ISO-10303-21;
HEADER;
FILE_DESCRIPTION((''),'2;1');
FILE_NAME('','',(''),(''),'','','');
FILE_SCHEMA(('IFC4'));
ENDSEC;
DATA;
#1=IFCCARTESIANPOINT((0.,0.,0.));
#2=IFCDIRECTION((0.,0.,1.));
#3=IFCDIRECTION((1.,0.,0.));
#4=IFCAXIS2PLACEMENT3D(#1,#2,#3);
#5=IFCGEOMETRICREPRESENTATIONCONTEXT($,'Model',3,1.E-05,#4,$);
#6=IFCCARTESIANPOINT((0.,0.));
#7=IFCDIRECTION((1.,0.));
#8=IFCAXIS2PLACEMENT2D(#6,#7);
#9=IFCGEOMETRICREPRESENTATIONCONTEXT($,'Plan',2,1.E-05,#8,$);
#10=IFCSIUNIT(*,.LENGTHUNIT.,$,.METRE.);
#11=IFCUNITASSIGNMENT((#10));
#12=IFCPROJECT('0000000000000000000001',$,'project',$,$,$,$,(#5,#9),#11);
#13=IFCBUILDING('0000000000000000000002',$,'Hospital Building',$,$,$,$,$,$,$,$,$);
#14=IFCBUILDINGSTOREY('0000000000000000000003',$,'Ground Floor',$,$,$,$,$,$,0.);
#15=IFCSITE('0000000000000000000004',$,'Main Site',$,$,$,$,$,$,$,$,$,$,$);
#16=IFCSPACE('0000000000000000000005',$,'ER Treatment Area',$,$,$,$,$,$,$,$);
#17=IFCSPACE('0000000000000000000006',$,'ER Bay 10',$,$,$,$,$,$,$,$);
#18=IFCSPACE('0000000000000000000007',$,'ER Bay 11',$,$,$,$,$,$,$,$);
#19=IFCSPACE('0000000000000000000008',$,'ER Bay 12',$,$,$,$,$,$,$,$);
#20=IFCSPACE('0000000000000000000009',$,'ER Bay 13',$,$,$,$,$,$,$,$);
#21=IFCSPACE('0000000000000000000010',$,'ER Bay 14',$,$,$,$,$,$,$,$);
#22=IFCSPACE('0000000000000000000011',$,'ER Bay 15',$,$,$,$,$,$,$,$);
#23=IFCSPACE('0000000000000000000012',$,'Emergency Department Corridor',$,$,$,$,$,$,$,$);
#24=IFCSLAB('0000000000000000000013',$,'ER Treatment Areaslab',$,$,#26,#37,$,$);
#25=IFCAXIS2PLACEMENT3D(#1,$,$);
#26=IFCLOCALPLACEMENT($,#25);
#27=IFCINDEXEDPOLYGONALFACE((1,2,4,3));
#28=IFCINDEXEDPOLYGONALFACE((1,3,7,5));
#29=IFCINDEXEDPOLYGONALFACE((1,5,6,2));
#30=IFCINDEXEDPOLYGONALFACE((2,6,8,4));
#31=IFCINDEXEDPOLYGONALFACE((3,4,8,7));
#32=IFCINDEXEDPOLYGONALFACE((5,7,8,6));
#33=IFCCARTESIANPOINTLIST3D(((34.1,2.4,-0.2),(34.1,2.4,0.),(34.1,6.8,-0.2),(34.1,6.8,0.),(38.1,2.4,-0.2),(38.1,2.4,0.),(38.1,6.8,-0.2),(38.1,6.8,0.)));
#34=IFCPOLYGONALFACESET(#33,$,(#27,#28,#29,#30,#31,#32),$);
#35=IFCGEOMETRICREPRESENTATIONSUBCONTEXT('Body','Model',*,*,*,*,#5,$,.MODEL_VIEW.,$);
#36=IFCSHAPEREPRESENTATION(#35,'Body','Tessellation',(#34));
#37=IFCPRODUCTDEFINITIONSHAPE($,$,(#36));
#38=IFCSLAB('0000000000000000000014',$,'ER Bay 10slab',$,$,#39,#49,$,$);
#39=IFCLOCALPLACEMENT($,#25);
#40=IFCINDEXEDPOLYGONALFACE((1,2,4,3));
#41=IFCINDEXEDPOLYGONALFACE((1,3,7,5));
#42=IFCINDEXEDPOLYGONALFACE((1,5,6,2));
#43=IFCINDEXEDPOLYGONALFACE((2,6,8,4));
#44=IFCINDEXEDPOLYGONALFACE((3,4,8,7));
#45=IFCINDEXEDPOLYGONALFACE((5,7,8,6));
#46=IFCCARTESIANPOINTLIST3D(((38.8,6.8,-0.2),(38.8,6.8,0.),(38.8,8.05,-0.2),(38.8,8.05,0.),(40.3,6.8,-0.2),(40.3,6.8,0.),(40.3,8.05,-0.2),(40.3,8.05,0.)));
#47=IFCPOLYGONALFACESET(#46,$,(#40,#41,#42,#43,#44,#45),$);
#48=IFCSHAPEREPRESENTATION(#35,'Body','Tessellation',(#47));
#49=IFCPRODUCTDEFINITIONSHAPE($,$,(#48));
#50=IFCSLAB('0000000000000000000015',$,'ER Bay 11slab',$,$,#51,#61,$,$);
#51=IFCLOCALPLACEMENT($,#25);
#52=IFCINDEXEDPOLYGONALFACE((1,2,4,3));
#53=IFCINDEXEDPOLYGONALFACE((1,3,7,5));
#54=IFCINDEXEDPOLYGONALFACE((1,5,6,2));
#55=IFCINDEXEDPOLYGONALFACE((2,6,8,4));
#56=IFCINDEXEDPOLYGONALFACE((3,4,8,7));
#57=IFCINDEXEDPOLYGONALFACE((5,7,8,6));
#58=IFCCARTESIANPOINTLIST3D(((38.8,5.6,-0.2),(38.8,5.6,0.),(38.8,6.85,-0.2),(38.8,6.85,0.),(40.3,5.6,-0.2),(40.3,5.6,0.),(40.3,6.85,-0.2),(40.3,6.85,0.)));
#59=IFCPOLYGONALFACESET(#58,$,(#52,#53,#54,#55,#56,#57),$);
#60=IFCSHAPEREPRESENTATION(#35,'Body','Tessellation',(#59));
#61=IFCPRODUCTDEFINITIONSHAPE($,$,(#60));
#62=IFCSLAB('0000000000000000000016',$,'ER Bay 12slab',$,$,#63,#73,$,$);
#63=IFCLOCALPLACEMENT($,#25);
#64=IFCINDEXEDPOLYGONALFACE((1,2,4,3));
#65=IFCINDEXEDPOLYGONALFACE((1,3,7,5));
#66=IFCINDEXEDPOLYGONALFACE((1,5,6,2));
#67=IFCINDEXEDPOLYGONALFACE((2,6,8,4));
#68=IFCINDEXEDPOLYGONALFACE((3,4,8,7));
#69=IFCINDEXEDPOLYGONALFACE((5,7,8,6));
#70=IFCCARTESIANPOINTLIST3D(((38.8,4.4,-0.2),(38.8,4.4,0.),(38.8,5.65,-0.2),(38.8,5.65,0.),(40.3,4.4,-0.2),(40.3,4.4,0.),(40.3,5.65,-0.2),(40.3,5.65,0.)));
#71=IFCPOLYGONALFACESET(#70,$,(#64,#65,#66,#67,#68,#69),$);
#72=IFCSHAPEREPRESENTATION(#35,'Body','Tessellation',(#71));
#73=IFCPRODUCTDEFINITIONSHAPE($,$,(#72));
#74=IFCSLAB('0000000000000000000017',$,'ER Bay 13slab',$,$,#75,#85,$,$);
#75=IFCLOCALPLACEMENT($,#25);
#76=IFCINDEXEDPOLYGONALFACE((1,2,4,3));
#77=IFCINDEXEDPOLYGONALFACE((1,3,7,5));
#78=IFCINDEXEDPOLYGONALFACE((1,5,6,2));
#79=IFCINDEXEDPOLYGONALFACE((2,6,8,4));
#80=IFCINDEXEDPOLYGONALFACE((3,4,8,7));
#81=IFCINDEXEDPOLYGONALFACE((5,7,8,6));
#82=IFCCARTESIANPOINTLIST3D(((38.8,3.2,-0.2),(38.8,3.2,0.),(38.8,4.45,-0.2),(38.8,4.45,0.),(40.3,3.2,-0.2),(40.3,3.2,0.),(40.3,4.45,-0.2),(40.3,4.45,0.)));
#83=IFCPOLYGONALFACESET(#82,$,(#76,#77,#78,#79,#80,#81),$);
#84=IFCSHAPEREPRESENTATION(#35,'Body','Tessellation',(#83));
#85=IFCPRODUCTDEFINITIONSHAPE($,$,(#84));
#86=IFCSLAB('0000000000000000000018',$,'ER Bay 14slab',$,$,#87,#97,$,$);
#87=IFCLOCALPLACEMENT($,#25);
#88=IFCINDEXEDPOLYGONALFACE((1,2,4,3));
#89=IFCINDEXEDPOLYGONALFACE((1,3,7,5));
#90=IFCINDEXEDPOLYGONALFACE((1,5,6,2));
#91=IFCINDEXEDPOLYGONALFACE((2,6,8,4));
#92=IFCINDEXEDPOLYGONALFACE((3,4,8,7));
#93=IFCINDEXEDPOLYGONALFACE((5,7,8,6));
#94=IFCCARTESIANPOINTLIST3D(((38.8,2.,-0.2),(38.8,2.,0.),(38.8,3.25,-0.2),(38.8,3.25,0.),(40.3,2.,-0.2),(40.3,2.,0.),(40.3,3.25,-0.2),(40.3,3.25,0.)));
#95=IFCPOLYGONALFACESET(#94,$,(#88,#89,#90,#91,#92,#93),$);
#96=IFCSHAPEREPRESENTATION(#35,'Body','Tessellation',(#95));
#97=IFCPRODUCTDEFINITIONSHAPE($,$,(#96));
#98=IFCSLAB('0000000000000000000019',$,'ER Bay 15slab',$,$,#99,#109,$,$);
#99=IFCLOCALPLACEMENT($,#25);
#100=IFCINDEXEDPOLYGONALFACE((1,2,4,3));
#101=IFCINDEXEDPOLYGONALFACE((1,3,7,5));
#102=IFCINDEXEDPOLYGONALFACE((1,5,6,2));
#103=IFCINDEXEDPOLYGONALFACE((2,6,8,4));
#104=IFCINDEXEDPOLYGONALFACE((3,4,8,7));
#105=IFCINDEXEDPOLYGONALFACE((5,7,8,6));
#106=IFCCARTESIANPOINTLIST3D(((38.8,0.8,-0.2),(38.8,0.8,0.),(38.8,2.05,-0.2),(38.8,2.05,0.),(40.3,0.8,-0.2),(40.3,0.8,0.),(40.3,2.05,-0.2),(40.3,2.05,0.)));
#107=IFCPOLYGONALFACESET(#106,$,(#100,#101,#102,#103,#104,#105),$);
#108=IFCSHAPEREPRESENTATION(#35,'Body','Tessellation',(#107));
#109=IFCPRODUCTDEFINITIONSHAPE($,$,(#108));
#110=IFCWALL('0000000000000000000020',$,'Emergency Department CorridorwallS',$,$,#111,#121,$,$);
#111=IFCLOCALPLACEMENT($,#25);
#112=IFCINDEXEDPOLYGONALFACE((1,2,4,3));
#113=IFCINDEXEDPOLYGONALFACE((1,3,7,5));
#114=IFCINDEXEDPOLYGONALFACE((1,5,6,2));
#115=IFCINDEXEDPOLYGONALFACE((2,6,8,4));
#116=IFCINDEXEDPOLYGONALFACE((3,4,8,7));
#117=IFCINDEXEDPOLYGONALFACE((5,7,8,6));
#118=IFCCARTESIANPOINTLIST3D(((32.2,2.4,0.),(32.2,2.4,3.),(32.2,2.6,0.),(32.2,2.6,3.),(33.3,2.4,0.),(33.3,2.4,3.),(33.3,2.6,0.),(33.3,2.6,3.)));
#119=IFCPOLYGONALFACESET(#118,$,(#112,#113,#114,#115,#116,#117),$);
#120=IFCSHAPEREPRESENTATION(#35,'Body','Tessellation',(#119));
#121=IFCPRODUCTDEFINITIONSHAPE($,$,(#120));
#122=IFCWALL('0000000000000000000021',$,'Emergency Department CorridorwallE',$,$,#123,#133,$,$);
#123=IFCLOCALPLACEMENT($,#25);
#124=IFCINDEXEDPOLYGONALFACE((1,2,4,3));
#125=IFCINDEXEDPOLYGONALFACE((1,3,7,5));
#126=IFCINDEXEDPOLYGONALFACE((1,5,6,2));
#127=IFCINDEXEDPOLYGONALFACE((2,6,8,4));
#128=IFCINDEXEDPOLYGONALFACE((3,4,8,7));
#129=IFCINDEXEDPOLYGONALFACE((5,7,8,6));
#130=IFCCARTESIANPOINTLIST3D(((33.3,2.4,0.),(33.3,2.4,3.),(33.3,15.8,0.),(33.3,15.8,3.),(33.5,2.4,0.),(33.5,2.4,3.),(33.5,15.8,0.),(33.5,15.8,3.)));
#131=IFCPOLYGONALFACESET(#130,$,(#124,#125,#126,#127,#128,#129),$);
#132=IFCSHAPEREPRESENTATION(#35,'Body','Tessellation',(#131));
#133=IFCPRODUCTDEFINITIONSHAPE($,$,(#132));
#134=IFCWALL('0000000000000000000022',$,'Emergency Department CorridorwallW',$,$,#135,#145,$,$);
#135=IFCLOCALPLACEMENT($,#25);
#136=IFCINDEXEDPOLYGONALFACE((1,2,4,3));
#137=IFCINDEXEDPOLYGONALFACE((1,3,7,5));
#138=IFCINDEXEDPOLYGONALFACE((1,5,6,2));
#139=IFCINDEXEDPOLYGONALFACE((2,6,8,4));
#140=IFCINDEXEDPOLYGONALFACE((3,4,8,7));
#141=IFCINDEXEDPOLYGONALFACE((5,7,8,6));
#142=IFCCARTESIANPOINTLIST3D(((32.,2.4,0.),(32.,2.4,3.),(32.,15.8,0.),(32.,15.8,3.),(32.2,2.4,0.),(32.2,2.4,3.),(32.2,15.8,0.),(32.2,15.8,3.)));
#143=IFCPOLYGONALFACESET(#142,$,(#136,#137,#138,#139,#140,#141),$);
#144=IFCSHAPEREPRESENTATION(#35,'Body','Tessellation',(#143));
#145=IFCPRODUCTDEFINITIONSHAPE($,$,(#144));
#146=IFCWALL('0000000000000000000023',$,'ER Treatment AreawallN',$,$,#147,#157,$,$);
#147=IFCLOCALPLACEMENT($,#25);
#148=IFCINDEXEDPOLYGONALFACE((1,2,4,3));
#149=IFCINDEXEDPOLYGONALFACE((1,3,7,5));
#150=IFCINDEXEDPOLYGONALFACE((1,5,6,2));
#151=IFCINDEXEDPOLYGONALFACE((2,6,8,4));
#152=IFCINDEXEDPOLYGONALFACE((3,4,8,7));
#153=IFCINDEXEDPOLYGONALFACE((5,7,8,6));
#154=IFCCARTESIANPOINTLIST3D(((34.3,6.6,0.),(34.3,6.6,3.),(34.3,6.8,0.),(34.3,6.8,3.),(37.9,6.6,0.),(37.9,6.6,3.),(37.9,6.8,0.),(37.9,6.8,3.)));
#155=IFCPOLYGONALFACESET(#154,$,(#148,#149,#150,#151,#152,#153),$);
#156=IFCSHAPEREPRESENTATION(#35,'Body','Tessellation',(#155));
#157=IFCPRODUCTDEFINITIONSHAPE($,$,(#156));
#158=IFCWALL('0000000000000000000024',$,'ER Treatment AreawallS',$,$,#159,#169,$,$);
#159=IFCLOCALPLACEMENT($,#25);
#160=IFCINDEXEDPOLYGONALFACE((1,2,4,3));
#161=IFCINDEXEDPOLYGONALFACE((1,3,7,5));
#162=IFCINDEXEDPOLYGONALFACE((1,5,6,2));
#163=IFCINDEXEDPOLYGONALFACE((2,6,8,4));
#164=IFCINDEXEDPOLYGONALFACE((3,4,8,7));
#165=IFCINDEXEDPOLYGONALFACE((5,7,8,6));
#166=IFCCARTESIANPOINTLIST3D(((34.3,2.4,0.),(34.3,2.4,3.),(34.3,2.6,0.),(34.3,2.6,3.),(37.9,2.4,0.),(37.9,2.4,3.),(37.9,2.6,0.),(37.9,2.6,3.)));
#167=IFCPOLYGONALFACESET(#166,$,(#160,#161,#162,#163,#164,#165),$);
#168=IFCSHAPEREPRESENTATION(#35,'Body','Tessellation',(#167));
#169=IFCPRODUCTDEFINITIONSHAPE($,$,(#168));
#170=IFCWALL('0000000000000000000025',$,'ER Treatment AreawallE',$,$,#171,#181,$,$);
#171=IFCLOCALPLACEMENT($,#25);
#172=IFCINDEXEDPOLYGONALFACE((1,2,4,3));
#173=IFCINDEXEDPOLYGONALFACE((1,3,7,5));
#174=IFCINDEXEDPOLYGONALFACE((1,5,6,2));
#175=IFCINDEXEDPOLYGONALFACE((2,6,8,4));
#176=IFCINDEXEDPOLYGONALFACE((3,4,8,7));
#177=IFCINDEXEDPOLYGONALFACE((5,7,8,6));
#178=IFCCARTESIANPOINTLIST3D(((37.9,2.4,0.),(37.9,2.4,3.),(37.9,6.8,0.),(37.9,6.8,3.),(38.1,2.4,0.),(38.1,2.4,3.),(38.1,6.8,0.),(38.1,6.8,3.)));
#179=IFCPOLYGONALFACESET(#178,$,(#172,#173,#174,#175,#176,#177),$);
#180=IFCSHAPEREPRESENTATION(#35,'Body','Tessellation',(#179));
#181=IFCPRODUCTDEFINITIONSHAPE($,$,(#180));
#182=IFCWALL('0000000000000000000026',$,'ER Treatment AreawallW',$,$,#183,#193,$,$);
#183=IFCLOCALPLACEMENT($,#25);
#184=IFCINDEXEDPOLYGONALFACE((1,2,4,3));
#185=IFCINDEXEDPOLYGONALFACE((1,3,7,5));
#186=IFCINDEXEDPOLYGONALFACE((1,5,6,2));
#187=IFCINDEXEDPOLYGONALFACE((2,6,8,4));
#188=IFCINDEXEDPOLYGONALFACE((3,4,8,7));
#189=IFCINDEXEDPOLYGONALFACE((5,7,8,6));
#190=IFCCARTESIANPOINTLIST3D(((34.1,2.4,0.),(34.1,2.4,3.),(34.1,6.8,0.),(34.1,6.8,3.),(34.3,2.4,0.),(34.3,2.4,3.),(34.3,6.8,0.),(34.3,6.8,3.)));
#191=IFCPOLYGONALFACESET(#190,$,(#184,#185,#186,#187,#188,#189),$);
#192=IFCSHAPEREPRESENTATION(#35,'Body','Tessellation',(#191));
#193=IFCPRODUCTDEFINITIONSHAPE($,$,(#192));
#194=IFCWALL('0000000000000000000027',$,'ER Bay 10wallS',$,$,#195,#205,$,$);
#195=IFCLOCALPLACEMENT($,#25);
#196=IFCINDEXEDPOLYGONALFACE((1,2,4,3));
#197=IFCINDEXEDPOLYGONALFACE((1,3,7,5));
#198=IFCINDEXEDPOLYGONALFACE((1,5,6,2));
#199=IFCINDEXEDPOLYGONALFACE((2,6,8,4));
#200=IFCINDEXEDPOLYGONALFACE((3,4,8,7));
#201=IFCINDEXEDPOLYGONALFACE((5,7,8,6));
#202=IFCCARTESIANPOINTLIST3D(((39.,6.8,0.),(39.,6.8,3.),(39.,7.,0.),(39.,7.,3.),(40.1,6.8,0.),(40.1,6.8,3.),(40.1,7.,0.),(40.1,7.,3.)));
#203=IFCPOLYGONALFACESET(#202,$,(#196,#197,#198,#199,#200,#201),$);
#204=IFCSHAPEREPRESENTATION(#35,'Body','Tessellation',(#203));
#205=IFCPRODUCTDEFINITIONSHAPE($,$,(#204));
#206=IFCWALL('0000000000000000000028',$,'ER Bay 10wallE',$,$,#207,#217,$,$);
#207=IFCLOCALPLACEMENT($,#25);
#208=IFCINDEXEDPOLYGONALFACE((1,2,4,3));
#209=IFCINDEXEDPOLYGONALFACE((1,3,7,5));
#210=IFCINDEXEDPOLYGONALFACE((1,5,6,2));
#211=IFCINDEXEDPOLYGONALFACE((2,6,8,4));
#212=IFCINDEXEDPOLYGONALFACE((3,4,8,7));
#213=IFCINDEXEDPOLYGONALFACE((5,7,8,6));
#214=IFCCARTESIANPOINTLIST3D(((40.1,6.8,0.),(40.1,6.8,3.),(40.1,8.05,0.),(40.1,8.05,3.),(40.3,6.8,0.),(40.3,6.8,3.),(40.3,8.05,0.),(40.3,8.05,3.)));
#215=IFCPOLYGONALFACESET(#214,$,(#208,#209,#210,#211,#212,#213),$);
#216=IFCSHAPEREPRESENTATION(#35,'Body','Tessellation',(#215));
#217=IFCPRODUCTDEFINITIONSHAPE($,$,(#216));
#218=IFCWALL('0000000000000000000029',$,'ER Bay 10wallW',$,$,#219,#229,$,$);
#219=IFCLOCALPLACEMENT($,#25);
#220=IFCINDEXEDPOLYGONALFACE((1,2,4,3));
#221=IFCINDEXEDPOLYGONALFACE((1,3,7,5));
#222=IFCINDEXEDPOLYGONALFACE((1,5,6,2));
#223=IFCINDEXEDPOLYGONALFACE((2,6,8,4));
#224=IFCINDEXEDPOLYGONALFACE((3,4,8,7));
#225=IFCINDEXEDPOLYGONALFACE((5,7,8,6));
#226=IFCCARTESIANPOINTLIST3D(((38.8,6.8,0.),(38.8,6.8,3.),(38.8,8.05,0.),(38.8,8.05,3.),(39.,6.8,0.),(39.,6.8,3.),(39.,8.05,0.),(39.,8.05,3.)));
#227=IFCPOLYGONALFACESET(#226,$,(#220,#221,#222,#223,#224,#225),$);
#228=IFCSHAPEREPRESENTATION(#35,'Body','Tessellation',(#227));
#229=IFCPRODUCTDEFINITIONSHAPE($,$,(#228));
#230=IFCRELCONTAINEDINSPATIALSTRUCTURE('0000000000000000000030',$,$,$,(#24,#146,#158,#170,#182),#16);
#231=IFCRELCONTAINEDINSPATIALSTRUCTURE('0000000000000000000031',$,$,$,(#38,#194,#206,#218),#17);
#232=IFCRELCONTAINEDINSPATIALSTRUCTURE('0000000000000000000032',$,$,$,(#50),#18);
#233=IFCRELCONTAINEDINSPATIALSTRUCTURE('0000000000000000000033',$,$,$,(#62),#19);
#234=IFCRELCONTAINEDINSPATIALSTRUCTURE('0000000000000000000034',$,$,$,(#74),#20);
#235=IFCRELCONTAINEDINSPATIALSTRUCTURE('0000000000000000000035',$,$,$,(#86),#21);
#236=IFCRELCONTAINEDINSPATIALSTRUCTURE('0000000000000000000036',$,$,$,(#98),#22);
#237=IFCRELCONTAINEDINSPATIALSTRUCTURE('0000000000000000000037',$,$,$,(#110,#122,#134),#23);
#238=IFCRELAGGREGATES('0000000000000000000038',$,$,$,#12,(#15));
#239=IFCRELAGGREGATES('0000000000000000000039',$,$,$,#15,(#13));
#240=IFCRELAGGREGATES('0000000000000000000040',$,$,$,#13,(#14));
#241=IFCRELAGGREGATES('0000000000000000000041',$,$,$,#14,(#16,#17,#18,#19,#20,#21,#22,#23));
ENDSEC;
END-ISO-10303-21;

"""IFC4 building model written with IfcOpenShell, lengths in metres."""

from ifc_helpers import new_model, si_unit, frame, origin_with_axes, origin_2d_with_axis, place, context, subcontext, project, spatial, indexed_curve, rectangle, outline, extrude, element, save


model = new_model("IFC4")

# Units and contexts
model_context = context("Model", 3, precision=1e-05, world=origin_with_axes())
plan_context = context("Plan", 2, precision=1e-05, world=origin_2d_with_axis())
body_context = subcontext(model_context, "Body", "Model", "MODEL_VIEW")
ifc_project = project(units=[si_unit("LENGTHUNIT", "METRE")], contexts=[model_context, plan_context])

# Site, building, storey, space
site = spatial("IfcSite", under=ifc_project, Name="Main Site")
building = spatial("IfcBuilding", under=site, Name="Hospital Building")
storey = spatial("IfcBuildingStorey", under=building, Name="Ground Floor", Elevation=0.0)
space_1 = spatial("IfcSpace", under=storey, Name="ER Treatment Area")

# Slab
slab_1_placement = place(None, frame((36.1, 4.6, -0.2), z_axis=(0.0, 0.0, 1.0), x_axis=(1.0, 0.0, 0.0)))
element("IfcSlab", 1, at=slab_1_placement, inside=space_1, Name="ER Treatment Areaslab", context=body_context, shape_type="SweptSolid", body=[
    extrude(rectangle(XDim=4.0, YDim=4.4), origin_with_axes(), (0.0, 0.0, 1.0), 0.2),
])

# Shared definitions
space_2 = spatial("IfcSpace", under=storey, Name="ER Bay 10")

# Slab
slab_2_placement = place(None, frame((39.55, 7.425, -0.2), z_axis=(0.0, 0.0, 1.0), x_axis=(1.0, 0.0, 0.0)))
element("IfcSlab", 2, at=slab_2_placement, inside=space_2, Name="ER Bay 10slab", context=body_context, shape_type="SweptSolid", body=[
    extrude(rectangle(XDim=1.5, YDim=1.25), origin_with_axes(), (0.0, 0.0, 1.0), 0.2),
])

# Shared definitions
space_3 = spatial("IfcSpace", under=storey, Name="ER Bay 11")

# Slab
slab_3_placement = place(None, frame((39.55, 6.225, -0.2), z_axis=(0.0, 0.0, 1.0), x_axis=(1.0, 0.0, 0.0)))
element("IfcSlab", 3, at=slab_3_placement, inside=space_3, Name="ER Bay 11slab", context=body_context, shape_type="SweptSolid", body=[
    extrude(rectangle(XDim=1.5, YDim=1.25), origin_with_axes(), (0.0, 0.0, 1.0), 0.2),
])

# Shared definitions
space_4 = spatial("IfcSpace", under=storey, Name="ER Bay 12")

# Slab
slab_4_placement = place(None, frame((39.55, 5.025, -0.2), z_axis=(0.0, 0.0, 1.0), x_axis=(1.0, 0.0, 0.0)))
element("IfcSlab", 4, at=slab_4_placement, inside=space_4, Name="ER Bay 12slab", context=body_context, shape_type="SweptSolid", body=[
    extrude(rectangle(XDim=1.5, YDim=1.25), origin_with_axes(), (0.0, 0.0, 1.0), 0.2),
])

# Shared definitions
space_5 = spatial("IfcSpace", under=storey, Name="ER Bay 13")

# Slab
slab_5_placement = place(None, frame((39.55, 3.825, -0.2), z_axis=(0.0, 0.0, 1.0), x_axis=(1.0, 0.0, 0.0)))
element("IfcSlab", 5, at=slab_5_placement, inside=space_5, Name="ER Bay 13slab", context=body_context, shape_type="SweptSolid", body=[
    extrude(rectangle(XDim=1.5, YDim=1.25), origin_with_axes(), (0.0, 0.0, 1.0), 0.2),
])

# Shared definitions
space_6 = spatial("IfcSpace", under=storey, Name="ER Bay 14")

# Slab
slab_6_placement = place(None, frame((39.55, 2.625, -0.2), z_axis=(0.0, 0.0, 1.0), x_axis=(1.0, 0.0, 0.0)))
element("IfcSlab", 6, at=slab_6_placement, inside=space_6, Name="ER Bay 14slab", context=body_context, shape_type="SweptSolid", body=[
    extrude(rectangle(XDim=1.5, YDim=1.25), origin_with_axes(), (0.0, 0.0, 1.0), 0.2),
])

# Shared definitions
space_7 = spatial("IfcSpace", under=storey, Name="ER Bay 15")

# Slab
slab_7_placement = place(None, frame((39.55, 1.425, -0.2), z_axis=(0.0, 0.0, 1.0), x_axis=(1.0, 0.0, 0.0)))
element("IfcSlab", 7, at=slab_7_placement, inside=space_7, Name="ER Bay 15slab", context=body_context, shape_type="SweptSolid", body=[
    extrude(rectangle(XDim=1.5, YDim=1.25), origin_with_axes(), (0.0, 0.0, 1.0), 0.2),
])

# Shared definitions
space_8 = spatial("IfcSpace", under=storey, Name="Emergency Department Corridor")

# Walls
wall_1_placement = place(None, frame((32.2, 2.4, 0.0), z_axis=(0.0, 0.0, 1.0), x_axis=(1.0, 0.0, 0.0)))
element("IfcWall", 8, at=wall_1_placement, inside=space_8, Name="Emergency Department CorridorwallS", context=body_context, shape_type="SweptSolid", body=[
    extrude(outline(indexed_curve([(0.0, 0.0), (0.0, 0.2), (1.1, 0.2), (1.1, 0.0), (0.0, 0.0)], self_intersect=False)), origin_with_axes(), (0.0, 0.0, 1.0), 3.0),
])
for number, where, z_axis, x_axis, name in (
    (9, (33.5, 2.4, 0.0), (0.0, 0.0, 1.0), (0.0, 1.0, 0.0), "Emergency Department CorridorwallE"),
    (10, (32.2, 2.4, 0.0), (0.0, 0.0, 1.0), (0.0, 1.0, 0.0), "Emergency Department CorridorwallW"),
):
    element("IfcWall", number, at=place(None, frame(where, z_axis=z_axis, x_axis=x_axis)), inside=space_8, Name=name, context=body_context, shape_type="SweptSolid", body=[
        extrude(outline(indexed_curve([(0.0, 0.0), (0.0, 0.2), (13.4, 0.2), (13.4, 0.0), (0.0, 0.0)], self_intersect=False)), origin_with_axes(), (0.0, 0.0, 1.0), 3.0),
    ])
for number, where, z_axis, x_axis, name in (
    (11, (34.3, 6.6, 0.0), (0.0, 0.0, 1.0), (1.0, 0.0, 0.0), "ER Treatment AreawallN"),
    (12, (34.3, 2.4, 0.0), (0.0, 0.0, 1.0), (1.0, 0.0, 0.0), "ER Treatment AreawallS"),
):
    element("IfcWall", number, at=place(None, frame(where, z_axis=z_axis, x_axis=x_axis)), inside=space_1, Name=name, context=body_context, shape_type="SweptSolid", body=[
        extrude(outline(indexed_curve([(0.0, 0.0), (0.0, 0.2), (3.6, 0.2), (3.6, 0.0), (0.0, 0.0)], self_intersect=False)), origin_with_axes(), (0.0, 0.0, 1.0), 3.0),
    ])
for number, where, z_axis, x_axis, name in (
    (13, (38.1, 2.4, 0.0), (0.0, 0.0, 1.0), (0.0, 1.0, 0.0), "ER Treatment AreawallE"),
    (14, (34.3, 2.4, 0.0), (0.0, 0.0, 1.0), (0.0, 1.0, 0.0), "ER Treatment AreawallW"),
):
    element("IfcWall", number, at=place(None, frame(where, z_axis=z_axis, x_axis=x_axis)), inside=space_1, Name=name, context=body_context, shape_type="SweptSolid", body=[
        extrude(outline(indexed_curve([(0.0, 0.0), (0.0, 0.2), (4.4, 0.2), (4.4, 0.0), (0.0, 0.0)], self_intersect=False)), origin_with_axes(), (0.0, 0.0, 1.0), 3.0),
    ])
wall_2_placement = place(None, frame((39.0, 6.8, 0.0), z_axis=(0.0, 0.0, 1.0), x_axis=(1.0, 0.0, 0.0)))
element("IfcWall", 15, at=wall_2_placement, inside=space_2, Name="ER Bay 10wallS", context=body_context, shape_type="SweptSolid", body=[
    extrude(outline(indexed_curve([(0.0, 0.0), (0.0, 0.2), (1.1, 0.2), (1.1, 0.0), (0.0, 0.0)], self_intersect=False)), origin_with_axes(), (0.0, 0.0, 1.0), 3.0),
])
for number, where, z_axis, x_axis, name in (
    (16, (40.3, 6.8, 0.0), (0.0, 0.0, 1.0), (0.0, 1.0, 0.0), "ER Bay 10wallE"),
    (17, (39.0, 6.8, 0.0), (0.0, 0.0, 1.0), (0.0, 1.0, 0.0), "ER Bay 10wallW"),
):
    element("IfcWall", number, at=place(None, frame(where, z_axis=z_axis, x_axis=x_axis)), inside=space_2, Name=name, context=body_context, shape_type="SweptSolid", body=[
        extrude(outline(indexed_curve([(0.0, 0.0), (0.0, 0.2), (1.25, 0.2), (1.25, 0.0), (0.0, 0.0)], self_intersect=False)), origin_with_axes(), (0.0, 0.0, 1.0), 3.0),
    ])

save(model, "model.ifc")
